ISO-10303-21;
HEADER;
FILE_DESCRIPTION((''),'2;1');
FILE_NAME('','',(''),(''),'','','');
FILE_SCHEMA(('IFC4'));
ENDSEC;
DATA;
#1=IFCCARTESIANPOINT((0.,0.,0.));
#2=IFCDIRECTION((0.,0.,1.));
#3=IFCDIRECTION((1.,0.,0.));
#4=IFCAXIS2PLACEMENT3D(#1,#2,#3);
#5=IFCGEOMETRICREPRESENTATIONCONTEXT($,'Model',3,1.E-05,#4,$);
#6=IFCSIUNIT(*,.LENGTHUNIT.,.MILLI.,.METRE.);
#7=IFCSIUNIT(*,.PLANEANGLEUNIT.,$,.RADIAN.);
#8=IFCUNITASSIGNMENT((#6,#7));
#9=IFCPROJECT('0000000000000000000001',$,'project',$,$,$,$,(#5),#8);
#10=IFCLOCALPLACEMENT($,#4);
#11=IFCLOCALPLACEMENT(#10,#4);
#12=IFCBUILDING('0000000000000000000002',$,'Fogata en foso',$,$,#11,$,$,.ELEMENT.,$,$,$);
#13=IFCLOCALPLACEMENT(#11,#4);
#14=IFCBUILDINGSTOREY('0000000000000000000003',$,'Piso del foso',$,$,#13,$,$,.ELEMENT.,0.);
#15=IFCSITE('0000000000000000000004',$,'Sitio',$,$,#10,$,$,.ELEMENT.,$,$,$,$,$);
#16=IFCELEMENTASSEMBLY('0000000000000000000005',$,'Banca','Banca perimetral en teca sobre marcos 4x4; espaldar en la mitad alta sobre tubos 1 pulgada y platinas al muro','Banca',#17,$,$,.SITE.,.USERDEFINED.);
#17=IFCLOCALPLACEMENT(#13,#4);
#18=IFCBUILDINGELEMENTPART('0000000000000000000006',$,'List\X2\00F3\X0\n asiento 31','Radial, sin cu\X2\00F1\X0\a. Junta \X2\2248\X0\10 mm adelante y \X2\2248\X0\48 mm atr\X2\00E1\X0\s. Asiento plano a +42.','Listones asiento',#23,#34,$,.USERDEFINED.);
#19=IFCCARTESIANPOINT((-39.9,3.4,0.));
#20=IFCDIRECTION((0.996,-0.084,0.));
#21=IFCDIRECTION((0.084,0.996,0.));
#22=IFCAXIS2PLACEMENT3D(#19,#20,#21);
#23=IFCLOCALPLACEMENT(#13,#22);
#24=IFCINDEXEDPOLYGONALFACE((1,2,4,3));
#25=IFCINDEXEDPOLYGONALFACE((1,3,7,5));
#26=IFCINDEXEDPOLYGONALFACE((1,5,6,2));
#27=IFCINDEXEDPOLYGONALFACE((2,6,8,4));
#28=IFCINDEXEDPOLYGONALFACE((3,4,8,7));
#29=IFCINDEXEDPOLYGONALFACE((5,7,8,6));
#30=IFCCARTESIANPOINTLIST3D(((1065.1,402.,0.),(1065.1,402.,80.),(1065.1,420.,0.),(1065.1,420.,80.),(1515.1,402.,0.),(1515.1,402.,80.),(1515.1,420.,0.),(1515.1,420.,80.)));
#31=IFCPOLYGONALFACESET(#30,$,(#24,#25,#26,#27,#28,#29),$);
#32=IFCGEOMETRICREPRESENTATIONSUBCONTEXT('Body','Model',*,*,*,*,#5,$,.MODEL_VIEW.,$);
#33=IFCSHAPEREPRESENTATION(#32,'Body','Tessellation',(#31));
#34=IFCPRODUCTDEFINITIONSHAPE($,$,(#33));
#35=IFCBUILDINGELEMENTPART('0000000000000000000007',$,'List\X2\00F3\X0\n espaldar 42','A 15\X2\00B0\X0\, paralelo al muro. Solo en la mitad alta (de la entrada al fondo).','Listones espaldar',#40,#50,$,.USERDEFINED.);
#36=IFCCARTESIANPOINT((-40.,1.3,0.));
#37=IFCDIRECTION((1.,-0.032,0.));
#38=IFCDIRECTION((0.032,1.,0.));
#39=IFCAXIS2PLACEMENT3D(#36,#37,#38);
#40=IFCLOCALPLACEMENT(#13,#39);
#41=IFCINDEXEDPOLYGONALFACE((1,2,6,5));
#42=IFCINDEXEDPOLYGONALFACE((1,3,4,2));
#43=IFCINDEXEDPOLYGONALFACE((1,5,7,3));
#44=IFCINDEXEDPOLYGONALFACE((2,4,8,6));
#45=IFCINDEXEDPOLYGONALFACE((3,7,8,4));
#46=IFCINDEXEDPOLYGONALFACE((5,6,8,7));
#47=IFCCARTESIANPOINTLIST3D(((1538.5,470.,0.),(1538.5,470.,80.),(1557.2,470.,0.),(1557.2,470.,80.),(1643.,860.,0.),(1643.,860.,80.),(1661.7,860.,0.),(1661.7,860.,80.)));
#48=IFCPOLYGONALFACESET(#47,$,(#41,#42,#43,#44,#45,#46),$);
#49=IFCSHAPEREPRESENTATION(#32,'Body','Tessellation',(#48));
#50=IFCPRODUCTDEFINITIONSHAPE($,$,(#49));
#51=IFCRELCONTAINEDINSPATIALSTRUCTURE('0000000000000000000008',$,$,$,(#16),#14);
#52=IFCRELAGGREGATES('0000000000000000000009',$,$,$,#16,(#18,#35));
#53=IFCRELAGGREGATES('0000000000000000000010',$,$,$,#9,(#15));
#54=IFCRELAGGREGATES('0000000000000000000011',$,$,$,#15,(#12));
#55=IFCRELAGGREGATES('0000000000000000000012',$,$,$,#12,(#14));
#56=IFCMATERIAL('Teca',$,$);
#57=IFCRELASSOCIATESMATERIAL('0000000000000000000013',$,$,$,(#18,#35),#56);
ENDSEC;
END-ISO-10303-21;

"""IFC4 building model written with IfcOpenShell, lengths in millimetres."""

from ifc_helpers import new_model, si_unit, frame, origin_with_axes, place, context, subcontext, project, spatial, polyline, outline, extrude, material, element, aggregate, save


model = new_model("IFC4")

# Units and contexts
model_context = context("Model", 3, precision=1e-05, world=origin_with_axes())
body_context = subcontext(model_context, "Body", "Model", "MODEL_VIEW")
ifc_project = project(units=[si_unit("LENGTHUNIT", "METRE", prefix="MILLI"), si_unit("PLANEANGLEUNIT", "RADIAN")], contexts=[model_context])

# Site, building, storey
site_placement = place(None, origin_with_axes())
site = spatial("IfcSite", under=ifc_project, at=site_placement, Name="Sitio", CompositionType="ELEMENT")
building_placement = place(site_placement, origin_with_axes())
building = spatial("IfcBuilding", under=site, at=building_placement, Name="Fogata en foso", CompositionType="ELEMENT")
storey_placement = place(building_placement, origin_with_axes())
storey = spatial("IfcBuildingStorey", under=building, at=storey_placement, Name="Piso del foso", CompositionType="ELEMENT", Elevation=0.0)

# Element assembly, building element parts
assembly_1_placement = place(storey_placement, origin_with_axes())
assembly_1 = element("IfcElementAssembly", 1, at=assembly_1_placement, inside=storey, Name="Banca", Description="Banca perimetral en teca sobre marcos 4x4; espaldar en la mitad alta sobre tubos 1 pulgada y platinas al muro", ObjectType="Banca", AssemblyPlace="SITE", PredefinedType="USERDEFINED")
ifc_material_1 = material(Name="Teca")
building_element_part_1_placement = place(storey_placement, frame((-39.9, 3.4, 0.0), z_axis=(0.996, -0.084, 0.0), x_axis=(0.084, 0.996, 0.0)))
building_element_part_1 = element("IfcBuildingElementPart", 2, at=building_element_part_1_placement, material=ifc_material_1, Name="Listón asiento 31", Description="Radial, sin cuña. Junta ≈10 mm adelante y ≈48 mm atrás. Asiento plano a +42.", ObjectType="Listones asiento", PredefinedType="USERDEFINED", context=body_context, shape_type="SweptSolid", body=[
    extrude(outline(polyline([(1065.1, 402.0), (1515.1, 402.0), (1515.1, 420.0), (1065.1, 420.0), (1065.1, 402.0)])), origin_with_axes(), (0.0, 0.0, 1.0), 80.0),
])
building_element_part_2_placement = place(storey_placement, frame((-40.0, 1.3, 0.0), z_axis=(1.0, -0.032, 0.0), x_axis=(0.032, 1.0, 0.0)))
building_element_part_2 = element("IfcBuildingElementPart", 3, at=building_element_part_2_placement, material=ifc_material_1, Name="Listón espaldar 42", Description="A 15°, paralelo al muro. Solo en la mitad alta (de la entrada al fondo).", ObjectType="Listones espaldar", PredefinedType="USERDEFINED", context=body_context, shape_type="SweptSolid", body=[
    extrude(outline(polyline([(1538.5, 470.0), (1557.2, 470.0), (1661.7, 860.0), (1643.0, 860.0), (1538.5, 470.0)])), origin_with_axes(), (0.0, 0.0, 1.0), 80.0),
])
aggregate(assembly_1, [building_element_part_1, building_element_part_2])

save(model, "model.ifc")
